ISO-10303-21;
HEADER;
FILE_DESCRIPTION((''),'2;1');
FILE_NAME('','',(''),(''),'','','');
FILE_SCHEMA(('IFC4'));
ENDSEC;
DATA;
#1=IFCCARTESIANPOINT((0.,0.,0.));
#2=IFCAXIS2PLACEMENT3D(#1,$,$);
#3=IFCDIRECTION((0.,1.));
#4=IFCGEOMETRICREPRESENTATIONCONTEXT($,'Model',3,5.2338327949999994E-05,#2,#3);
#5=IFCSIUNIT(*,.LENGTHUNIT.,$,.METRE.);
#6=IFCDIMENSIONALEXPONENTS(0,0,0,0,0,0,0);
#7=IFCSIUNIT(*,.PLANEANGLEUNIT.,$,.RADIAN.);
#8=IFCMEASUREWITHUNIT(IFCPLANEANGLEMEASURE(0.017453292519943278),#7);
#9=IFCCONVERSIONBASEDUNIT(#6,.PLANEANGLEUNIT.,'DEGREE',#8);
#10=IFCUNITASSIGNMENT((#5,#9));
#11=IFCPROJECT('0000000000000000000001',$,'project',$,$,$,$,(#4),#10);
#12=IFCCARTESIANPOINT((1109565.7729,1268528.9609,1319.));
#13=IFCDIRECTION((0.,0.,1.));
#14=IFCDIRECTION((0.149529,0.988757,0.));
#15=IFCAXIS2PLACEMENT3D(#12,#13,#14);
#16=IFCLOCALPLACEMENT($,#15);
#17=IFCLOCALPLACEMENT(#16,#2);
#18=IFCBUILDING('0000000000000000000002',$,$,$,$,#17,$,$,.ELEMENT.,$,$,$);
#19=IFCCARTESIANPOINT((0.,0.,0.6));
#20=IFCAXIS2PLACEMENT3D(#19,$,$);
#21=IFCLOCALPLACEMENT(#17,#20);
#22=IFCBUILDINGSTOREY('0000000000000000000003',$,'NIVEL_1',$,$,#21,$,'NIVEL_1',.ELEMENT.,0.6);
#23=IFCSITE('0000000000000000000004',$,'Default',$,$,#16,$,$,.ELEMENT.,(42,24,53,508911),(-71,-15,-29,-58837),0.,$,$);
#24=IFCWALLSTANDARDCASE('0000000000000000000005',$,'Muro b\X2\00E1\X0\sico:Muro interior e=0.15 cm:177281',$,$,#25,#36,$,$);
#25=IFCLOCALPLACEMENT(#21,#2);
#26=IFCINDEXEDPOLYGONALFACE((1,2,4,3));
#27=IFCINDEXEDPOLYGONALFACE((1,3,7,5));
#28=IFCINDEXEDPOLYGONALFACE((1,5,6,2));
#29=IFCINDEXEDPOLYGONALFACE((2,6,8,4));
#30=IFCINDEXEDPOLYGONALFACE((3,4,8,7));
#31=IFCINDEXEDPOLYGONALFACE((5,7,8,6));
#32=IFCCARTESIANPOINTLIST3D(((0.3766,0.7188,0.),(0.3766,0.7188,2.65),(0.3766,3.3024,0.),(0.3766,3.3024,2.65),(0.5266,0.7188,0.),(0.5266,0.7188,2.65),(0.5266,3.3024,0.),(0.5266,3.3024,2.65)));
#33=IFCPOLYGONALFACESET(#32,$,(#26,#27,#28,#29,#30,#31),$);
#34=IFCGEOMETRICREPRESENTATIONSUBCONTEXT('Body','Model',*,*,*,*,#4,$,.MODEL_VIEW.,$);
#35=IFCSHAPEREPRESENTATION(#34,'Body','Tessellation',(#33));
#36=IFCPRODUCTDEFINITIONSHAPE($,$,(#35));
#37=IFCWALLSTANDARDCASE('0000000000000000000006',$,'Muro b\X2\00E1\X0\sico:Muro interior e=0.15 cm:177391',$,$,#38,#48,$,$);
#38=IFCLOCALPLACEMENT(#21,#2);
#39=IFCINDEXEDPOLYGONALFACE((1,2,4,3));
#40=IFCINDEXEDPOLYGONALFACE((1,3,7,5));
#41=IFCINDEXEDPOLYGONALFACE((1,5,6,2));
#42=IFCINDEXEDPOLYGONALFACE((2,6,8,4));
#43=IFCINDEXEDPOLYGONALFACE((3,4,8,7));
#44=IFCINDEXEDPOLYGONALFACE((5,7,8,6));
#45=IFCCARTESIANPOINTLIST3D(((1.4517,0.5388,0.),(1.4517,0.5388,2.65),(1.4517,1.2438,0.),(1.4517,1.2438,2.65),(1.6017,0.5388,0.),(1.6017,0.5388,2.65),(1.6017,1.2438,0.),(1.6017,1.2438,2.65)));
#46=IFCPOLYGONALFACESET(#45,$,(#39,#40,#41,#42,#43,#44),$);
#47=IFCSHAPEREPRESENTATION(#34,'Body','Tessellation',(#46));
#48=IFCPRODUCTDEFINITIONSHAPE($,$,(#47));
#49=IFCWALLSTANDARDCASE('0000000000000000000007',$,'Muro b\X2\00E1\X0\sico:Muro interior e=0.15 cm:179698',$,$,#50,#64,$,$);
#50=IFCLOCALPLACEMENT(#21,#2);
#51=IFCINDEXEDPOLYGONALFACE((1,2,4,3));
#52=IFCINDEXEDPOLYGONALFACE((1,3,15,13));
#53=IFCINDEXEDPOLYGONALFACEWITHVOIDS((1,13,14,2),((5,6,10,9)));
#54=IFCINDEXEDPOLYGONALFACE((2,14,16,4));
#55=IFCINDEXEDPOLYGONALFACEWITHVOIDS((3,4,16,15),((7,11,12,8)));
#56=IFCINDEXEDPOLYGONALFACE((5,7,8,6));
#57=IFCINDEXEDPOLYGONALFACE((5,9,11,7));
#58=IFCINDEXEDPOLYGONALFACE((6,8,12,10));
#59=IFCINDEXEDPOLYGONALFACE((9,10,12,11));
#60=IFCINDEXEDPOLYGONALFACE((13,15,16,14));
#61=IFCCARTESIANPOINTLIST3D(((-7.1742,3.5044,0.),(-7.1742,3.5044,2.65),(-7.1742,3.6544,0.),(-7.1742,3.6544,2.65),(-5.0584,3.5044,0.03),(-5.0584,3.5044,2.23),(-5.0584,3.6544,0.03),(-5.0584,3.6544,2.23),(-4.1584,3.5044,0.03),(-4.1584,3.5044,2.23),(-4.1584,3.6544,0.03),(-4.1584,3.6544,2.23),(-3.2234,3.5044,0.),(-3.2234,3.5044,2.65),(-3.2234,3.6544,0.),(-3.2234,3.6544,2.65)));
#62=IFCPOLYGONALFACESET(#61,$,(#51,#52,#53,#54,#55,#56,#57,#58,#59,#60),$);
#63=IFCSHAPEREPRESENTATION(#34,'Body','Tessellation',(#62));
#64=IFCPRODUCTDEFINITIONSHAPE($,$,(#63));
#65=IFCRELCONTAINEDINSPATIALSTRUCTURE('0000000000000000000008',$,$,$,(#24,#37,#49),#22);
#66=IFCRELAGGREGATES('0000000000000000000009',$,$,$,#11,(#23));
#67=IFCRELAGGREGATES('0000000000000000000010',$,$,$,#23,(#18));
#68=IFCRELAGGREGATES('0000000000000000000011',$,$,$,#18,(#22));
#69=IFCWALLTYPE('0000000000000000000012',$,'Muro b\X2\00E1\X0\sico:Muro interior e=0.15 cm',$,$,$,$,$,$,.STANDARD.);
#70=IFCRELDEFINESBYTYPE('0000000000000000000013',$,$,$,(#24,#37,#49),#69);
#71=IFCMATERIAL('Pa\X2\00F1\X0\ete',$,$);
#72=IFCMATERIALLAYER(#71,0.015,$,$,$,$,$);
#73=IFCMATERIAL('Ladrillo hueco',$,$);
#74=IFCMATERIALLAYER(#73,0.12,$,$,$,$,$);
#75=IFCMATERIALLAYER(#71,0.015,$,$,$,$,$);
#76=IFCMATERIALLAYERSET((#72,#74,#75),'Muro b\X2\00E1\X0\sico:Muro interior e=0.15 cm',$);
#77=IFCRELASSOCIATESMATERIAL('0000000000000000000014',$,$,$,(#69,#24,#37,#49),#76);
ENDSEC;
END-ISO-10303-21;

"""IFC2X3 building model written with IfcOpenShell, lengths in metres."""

from ifc_helpers import new_model, entity, si_unit, converted_unit, direction, frame, frame_2d, origin, place, context, subcontext, project, spatial, rectangle, extrude, material, layer, layer_set, layer_usage, type_object, element, save


model = new_model("IFC2X3")

# Units and contexts
model_context = context("Model", 3, precision=5.2338327949999994e-05, world=origin(), true_north=direction((0.0, 1.0)))
body_context = subcontext(model_context, "Body", "Model", "MODEL_VIEW")
ifc_project = project(units=[si_unit("LENGTHUNIT", "METRE"), converted_unit("PLANEANGLEUNIT", "DEGREE", entity("IfcPlaneAngleMeasure", 0.017453292519943278), si_unit("PLANEANGLEUNIT", "RADIAN"), dimensions=[0, 0, 0, 0, 0, 0, 0])], contexts=[model_context])

# Site, building, storey
site_placement = place(None, frame((1109565.7729, 1268528.9609, 1319.0), z_axis=(0.0, 0.0, 1.0), x_axis=(0.149529, 0.988757, 0.0)))
site = spatial("IfcSite", under=ifc_project, at=site_placement, Name="Default", CompositionType="ELEMENT", RefLatitude=(42, 24, 53, 508911), RefLongitude=(-71, -15, -29, -58837), RefElevation=0.0)
building_placement = place(site_placement, origin())
building = spatial("IfcBuilding", under=site, at=building_placement, CompositionType="ELEMENT")
storey_placement = place(building_placement, frame((0.0, 0.0, 0.6)))
storey = spatial("IfcBuildingStorey", under=building, at=storey_placement, Name="NIVEL_1", LongName="NIVEL_1", CompositionType="ELEMENT", Elevation=0.6)

# Walls
ifc_material_1 = material(Name="Pañete")
ifc_layer_1 = layer(ifc_material_1, 0.015)
ifc_material_2 = material(Name="Ladrillo hueco")
ifc_layer_2 = layer(ifc_material_2, 0.12)
ifc_layer_3 = layer(ifc_material_1, 0.015)
ifc_layer_set_1 = layer_set([ifc_layer_1, ifc_layer_2, ifc_layer_3], Name="Muro básico:Muro interior e=0.15 cm")
ifc_layer_usage_1 = layer_usage(ifc_layer_set_1, "AXIS2", "NEGATIVE", 0.075)
wall_type_1 = type_object("IfcWallType", Name="Muro básico:Muro interior e=0.15 cm", PredefinedType="STANDARD", material=ifc_layer_set_1)
wall_1_placement = place(storey_placement, frame((0.4516, 0.7188, 0.0), z_axis=(0.0, 0.0, 1.0), x_axis=(0.0, 1.0, 0.0)))
element("IfcWallStandardCase", 1, at=wall_1_placement, inside=storey, type_object=wall_type_1, material=ifc_layer_usage_1, Name="Muro básico:Muro interior e=0.15 cm:177281", context=body_context, shape_type="SweptSolid", body=[
    extrude(rectangle(XDim=2.5836, YDim=0.15, at=frame_2d((1.2918, 0.0), x_axis=(-1.0, 0.0))), origin(), (0.0, 0.0, 1.0), 2.65),
])
ifc_layer_usage_2 = layer_usage(ifc_layer_set_1, "AXIS2", "POSITIVE", -0.075)
wall_2_placement = place(storey_placement, frame((1.5267, 1.2438, 0.0), z_axis=(0.0, 0.0, 1.0), x_axis=(0.0, -1.0, 0.0)))
element("IfcWallStandardCase", 2, at=wall_2_placement, inside=storey, type_object=wall_type_1, material=ifc_layer_usage_2, Name="Muro básico:Muro interior e=0.15 cm:177391", context=body_context, shape_type="SweptSolid", body=[
    extrude(rectangle(XDim=0.705, YDim=0.15, at=frame_2d((0.3525, 0.0), x_axis=(-1.0, 0.0))), origin(), (0.0, 0.0, 1.0), 2.65),
])

# Wall, opening
ifc_layer_usage_3 = layer_usage(ifc_layer_set_1, "AXIS2", "NEGATIVE", 0.075)
wall_3_placement = place(storey_placement, frame((-3.2234, 3.5794, 0.0), z_axis=(0.0, 0.0, 1.0), x_axis=(-1.0, 0.0, 0.0)))
wall_3 = element("IfcWallStandardCase", 3, at=wall_3_placement, inside=storey, type_object=wall_type_1, material=ifc_layer_usage_3, Name="Muro básico:Muro interior e=0.15 cm:179698", context=body_context, shape_type="SweptSolid", body=[
    extrude(rectangle(XDim=3.9509, YDim=0.15, at=frame_2d((1.9754, 0.0), x_axis=(-1.0, 0.0))), origin(), (0.0, 0.0, 1.0), 2.65),
])
opening_1_placement = place(wall_3_placement, frame((1.835, 0.075, 0.03)))
element("IfcOpeningElement", 4, at=opening_1_placement, cuts=wall_3, ObjectType="Opening", context=body_context, shape_type="SweptSolid", body=[
    extrude(rectangle(XDim=2.2, YDim=0.9, at=frame_2d((1.1, 0.45), x_axis=(1.0, 0.0))), frame((0.0, 0.0, 0.0), z_axis=(0.0, -1.0, 0.0), x_axis=(0.0, 0.0, 1.0)), (0.0, 0.0, 1.0), 0.15),
])

save(model, "model.ifc")
